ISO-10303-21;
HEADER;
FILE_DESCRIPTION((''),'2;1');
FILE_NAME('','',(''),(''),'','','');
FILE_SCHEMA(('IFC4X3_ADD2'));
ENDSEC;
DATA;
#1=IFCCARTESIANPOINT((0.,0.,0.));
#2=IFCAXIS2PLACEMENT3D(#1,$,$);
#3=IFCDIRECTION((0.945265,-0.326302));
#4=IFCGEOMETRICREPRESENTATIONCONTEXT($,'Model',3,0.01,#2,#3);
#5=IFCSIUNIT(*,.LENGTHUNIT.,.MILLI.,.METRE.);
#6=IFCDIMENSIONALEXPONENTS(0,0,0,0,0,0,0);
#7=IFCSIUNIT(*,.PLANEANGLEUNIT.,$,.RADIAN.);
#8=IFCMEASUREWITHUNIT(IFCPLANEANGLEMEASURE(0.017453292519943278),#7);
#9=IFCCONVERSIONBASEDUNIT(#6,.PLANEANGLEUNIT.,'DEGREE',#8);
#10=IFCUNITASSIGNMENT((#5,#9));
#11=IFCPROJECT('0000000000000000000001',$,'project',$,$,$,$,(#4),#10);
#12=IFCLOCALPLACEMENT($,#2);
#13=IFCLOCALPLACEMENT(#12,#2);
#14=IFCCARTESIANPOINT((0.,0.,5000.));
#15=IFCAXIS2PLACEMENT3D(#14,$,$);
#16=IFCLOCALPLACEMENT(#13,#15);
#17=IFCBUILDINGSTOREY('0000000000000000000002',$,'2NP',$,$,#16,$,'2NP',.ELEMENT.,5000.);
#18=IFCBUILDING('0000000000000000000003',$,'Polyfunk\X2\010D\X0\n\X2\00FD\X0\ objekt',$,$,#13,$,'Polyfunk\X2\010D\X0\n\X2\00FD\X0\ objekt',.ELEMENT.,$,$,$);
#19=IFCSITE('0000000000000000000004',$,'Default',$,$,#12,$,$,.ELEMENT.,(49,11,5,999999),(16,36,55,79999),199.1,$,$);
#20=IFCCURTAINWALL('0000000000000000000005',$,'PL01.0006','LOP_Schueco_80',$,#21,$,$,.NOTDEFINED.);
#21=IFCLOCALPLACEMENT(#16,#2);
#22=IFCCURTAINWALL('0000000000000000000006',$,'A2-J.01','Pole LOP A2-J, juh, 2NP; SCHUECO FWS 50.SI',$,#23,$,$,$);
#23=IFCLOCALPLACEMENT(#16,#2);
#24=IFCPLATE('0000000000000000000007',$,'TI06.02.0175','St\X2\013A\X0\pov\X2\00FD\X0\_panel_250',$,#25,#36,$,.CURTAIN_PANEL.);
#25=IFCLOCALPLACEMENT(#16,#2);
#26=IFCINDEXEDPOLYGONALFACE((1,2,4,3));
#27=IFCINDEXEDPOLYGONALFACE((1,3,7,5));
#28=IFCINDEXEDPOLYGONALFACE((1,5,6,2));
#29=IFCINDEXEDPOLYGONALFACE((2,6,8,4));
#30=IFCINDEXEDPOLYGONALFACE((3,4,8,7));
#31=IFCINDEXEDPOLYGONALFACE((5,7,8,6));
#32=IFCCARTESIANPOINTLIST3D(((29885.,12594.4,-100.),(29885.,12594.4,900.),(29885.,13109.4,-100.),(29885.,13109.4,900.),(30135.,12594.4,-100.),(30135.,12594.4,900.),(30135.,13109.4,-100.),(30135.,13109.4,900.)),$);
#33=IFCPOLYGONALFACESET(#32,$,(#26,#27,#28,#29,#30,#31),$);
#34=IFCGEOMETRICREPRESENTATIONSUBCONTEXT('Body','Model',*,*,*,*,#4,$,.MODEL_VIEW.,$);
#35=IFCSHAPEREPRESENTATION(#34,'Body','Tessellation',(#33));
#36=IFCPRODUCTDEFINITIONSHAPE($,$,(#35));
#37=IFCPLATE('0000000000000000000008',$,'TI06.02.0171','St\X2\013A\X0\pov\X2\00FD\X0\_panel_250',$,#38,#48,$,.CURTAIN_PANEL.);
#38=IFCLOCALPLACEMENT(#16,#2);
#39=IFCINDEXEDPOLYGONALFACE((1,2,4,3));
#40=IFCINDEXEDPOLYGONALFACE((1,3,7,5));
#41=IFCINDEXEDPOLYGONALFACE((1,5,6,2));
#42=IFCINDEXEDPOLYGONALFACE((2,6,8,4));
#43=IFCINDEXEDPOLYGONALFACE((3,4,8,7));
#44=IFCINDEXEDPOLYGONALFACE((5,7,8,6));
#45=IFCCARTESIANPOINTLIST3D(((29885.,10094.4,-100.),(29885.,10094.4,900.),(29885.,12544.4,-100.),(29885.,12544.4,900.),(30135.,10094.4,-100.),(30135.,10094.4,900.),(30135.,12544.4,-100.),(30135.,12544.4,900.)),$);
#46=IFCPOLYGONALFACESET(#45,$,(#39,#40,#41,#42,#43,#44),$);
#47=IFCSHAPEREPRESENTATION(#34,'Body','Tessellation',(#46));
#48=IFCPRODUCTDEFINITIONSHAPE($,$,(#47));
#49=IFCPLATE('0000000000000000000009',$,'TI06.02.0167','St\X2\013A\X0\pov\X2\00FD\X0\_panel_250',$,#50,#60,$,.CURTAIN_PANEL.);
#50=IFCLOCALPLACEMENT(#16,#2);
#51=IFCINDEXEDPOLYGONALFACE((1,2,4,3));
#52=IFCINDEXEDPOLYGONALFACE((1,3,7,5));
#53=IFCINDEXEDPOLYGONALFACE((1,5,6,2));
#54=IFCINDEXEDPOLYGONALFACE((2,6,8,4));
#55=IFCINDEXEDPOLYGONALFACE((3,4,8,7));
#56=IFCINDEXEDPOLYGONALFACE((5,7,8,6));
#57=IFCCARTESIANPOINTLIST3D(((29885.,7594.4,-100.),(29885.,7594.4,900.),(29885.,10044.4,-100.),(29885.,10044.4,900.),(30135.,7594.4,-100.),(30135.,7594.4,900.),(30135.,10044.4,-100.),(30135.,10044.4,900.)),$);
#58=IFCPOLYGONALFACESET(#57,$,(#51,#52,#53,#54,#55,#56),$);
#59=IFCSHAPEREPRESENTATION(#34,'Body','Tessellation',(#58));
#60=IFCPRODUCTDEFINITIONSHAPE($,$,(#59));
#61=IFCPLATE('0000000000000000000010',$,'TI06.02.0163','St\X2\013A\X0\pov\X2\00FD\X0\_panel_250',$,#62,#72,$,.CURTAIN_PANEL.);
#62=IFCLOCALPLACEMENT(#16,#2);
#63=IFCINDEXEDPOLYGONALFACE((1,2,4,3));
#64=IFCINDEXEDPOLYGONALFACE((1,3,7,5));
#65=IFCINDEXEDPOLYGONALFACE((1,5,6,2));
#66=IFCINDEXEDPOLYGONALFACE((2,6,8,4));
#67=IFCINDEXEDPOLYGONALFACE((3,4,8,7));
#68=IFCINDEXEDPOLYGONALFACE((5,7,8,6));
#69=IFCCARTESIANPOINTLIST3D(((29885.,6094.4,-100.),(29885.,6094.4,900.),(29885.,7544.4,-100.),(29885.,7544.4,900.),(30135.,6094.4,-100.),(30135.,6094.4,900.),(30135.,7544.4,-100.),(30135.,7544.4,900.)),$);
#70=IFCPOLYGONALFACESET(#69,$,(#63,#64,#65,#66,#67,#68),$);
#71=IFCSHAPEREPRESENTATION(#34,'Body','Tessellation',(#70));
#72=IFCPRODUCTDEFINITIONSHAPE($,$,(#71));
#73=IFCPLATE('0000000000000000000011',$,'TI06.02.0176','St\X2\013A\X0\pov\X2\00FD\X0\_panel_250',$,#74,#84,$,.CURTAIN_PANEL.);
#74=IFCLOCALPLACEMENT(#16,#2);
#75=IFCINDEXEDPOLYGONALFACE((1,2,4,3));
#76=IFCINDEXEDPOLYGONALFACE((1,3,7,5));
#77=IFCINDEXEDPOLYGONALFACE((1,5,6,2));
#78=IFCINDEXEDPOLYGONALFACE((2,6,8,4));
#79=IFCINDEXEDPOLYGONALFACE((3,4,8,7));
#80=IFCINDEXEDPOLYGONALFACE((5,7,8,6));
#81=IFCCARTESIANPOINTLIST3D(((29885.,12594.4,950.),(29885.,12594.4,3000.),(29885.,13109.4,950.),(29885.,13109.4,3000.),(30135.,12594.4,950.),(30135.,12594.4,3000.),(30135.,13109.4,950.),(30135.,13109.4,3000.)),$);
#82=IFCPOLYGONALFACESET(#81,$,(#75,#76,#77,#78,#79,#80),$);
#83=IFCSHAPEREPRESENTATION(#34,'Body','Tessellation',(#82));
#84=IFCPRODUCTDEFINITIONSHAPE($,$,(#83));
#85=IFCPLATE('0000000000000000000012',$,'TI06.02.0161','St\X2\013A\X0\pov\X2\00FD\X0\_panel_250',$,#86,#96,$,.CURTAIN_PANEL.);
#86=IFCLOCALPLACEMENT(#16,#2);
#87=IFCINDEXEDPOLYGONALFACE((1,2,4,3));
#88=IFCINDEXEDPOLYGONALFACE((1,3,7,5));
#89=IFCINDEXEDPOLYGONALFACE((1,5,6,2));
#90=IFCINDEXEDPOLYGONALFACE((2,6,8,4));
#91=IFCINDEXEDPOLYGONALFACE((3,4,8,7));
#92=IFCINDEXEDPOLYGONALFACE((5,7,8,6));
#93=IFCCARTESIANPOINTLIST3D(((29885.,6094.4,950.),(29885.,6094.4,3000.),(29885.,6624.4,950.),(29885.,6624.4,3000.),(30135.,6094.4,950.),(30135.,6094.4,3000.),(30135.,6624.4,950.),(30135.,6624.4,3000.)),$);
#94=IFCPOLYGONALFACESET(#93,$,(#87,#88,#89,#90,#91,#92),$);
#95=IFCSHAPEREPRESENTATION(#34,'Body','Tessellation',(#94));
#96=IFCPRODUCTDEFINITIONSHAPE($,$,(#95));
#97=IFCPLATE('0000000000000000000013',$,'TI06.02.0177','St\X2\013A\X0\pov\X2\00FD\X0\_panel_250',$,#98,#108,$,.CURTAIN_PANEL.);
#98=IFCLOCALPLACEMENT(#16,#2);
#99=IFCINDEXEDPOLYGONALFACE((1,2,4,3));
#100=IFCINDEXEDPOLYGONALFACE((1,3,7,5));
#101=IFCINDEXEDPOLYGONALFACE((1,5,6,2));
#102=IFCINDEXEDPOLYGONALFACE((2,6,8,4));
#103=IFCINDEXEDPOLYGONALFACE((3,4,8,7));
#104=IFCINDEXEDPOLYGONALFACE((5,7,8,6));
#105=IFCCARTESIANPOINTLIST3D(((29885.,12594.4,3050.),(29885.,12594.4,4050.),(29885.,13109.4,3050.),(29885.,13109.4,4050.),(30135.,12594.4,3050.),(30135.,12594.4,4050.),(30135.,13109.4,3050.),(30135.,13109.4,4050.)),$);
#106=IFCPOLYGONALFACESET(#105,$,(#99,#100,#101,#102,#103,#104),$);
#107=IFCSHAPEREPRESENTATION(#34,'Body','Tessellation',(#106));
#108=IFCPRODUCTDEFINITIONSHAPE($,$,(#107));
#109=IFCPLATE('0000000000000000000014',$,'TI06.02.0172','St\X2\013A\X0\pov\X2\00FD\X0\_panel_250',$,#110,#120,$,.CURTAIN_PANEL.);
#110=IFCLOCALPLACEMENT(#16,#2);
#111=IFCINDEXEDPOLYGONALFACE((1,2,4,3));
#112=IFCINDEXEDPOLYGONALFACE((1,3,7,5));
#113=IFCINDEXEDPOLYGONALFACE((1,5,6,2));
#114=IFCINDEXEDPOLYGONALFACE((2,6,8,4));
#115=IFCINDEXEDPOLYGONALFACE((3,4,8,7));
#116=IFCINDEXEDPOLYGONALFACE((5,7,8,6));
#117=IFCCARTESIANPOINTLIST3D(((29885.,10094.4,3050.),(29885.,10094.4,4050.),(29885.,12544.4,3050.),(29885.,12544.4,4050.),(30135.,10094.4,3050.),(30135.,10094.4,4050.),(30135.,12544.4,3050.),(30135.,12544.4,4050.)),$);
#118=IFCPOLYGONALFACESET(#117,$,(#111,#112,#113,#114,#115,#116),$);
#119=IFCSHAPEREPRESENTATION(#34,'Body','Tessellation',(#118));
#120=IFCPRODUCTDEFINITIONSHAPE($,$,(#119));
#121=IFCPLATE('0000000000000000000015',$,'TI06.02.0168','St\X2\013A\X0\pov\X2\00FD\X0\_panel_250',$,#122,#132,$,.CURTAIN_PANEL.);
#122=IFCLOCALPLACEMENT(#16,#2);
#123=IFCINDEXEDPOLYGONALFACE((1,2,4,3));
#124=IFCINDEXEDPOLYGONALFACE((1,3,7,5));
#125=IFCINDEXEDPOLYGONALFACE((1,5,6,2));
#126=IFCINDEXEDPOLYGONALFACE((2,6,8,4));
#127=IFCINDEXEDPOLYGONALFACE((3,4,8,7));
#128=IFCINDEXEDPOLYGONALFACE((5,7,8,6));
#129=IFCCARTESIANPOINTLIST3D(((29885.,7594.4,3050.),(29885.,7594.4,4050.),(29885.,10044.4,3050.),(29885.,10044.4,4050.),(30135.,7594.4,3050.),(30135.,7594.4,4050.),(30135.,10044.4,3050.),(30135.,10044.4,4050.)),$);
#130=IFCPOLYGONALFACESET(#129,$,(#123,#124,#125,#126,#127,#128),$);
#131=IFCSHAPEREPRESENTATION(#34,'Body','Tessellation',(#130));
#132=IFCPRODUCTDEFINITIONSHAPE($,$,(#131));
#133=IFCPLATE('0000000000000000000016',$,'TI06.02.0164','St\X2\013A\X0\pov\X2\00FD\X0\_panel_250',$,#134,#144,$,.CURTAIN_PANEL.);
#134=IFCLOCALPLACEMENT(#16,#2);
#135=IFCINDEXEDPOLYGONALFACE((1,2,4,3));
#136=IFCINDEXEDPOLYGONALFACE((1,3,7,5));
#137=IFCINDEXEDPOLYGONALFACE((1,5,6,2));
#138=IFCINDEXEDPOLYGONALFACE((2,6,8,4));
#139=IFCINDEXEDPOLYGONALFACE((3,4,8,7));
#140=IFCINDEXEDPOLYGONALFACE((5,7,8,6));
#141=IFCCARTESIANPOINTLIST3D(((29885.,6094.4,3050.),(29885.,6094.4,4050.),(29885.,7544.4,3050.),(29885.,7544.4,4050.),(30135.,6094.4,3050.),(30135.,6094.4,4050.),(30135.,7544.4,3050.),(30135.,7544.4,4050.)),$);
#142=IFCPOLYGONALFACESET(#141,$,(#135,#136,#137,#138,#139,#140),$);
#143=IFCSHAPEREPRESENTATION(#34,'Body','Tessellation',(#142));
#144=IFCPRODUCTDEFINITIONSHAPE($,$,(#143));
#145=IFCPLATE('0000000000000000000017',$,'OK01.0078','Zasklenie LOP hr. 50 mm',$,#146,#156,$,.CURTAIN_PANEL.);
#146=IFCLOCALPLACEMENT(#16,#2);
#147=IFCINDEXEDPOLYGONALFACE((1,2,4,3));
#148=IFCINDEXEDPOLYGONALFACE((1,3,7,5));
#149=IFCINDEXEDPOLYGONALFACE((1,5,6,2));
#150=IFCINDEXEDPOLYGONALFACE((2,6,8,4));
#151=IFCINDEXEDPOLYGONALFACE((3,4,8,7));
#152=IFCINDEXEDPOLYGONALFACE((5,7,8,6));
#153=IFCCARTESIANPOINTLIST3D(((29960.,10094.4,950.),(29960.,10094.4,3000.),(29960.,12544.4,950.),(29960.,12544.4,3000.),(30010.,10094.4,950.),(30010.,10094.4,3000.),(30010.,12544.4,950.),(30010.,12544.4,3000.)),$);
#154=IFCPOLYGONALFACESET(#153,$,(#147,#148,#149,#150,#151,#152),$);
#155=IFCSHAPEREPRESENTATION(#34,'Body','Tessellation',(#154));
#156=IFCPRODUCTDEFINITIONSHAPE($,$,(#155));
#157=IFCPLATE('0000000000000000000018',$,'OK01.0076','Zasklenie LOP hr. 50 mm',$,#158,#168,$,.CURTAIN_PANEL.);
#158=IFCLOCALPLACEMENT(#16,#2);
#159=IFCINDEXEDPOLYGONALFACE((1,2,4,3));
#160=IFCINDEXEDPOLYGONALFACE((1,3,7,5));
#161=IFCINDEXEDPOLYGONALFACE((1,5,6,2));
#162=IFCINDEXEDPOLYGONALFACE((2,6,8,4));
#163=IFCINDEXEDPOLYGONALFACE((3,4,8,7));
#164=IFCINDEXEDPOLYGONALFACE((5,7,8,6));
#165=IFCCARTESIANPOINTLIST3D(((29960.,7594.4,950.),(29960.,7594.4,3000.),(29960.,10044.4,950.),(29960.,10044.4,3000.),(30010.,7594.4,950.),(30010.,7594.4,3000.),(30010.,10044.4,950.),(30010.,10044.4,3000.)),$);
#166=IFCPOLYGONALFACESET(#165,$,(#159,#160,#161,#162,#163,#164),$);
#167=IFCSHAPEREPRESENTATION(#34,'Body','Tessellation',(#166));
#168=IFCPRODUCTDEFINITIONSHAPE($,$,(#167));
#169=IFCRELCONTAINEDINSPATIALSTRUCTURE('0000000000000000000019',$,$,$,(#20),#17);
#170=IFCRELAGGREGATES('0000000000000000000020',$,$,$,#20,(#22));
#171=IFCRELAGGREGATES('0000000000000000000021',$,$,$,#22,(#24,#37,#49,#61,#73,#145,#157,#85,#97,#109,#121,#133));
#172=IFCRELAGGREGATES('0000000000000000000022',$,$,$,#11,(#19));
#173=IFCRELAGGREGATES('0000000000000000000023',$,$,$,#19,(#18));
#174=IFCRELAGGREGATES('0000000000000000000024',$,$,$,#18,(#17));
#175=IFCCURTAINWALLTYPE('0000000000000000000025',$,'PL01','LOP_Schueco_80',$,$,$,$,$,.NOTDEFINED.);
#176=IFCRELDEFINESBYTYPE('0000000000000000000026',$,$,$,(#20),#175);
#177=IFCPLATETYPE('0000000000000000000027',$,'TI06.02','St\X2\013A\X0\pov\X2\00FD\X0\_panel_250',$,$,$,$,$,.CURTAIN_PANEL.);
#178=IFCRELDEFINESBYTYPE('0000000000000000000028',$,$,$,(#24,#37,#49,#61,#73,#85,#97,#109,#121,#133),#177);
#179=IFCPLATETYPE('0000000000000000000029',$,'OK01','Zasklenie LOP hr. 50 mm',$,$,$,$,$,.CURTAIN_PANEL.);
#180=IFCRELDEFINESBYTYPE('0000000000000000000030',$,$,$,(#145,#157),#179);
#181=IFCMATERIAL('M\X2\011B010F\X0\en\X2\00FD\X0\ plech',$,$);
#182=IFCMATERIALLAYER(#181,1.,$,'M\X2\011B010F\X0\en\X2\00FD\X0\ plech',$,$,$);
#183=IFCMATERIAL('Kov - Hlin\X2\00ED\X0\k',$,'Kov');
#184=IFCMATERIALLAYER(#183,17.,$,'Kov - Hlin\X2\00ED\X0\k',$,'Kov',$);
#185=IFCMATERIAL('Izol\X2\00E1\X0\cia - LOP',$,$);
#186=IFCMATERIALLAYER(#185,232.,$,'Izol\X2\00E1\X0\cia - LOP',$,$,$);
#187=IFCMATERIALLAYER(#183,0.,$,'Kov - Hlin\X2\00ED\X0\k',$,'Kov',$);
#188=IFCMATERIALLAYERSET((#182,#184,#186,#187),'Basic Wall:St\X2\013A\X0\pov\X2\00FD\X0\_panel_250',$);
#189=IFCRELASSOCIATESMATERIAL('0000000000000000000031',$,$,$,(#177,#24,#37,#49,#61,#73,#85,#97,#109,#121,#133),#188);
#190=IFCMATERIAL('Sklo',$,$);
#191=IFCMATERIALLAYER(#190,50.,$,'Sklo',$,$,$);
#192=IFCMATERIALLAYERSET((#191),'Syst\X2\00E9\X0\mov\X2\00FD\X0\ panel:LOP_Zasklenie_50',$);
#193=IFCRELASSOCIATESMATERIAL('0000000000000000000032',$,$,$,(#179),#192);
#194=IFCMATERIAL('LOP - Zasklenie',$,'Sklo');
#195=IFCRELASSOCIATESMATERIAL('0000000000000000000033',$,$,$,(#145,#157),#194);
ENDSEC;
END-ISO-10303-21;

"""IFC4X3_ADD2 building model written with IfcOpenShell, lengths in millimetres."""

from ifc_helpers import new_model, entity, si_unit, converted_unit, direction, frame, frame_2d, origin, origin_2d_with_axis, place, context, subcontext, project, spatial, rectangle, extrude, source, transform, mapped, material, layer, layer_set, layer_usage, type_object, element, aggregate, save


model = new_model("IFC4X3_ADD2")

# Units and contexts
model_context = context("Model", 3, precision=0.01, world=origin(), true_north=direction((0.945265, -0.326302)))
body_context = subcontext(model_context, "Body", "Model", "MODEL_VIEW")
ifc_project = project(units=[si_unit("LENGTHUNIT", "METRE", prefix="MILLI"), converted_unit("PLANEANGLEUNIT", "DEGREE", entity("IfcPlaneAngleMeasure", 0.017453292519943278), si_unit("PLANEANGLEUNIT", "RADIAN"), dimensions=[0, 0, 0, 0, 0, 0, 0])], contexts=[model_context])

# Site, building, storey
site_placement = place(None, origin())
site = spatial("IfcSite", under=ifc_project, at=site_placement, Name="Default", CompositionType="ELEMENT", RefLatitude=(49, 11, 5, 999999), RefLongitude=(16, 36, 55, 79999), RefElevation=199.1)
building_placement = place(site_placement, origin())
building = spatial("IfcBuilding", under=site, at=building_placement, Name="Polyfunkčný objekt", LongName="Polyfunkčný objekt", CompositionType="ELEMENT")
storey_placement = place(building_placement, frame((0.0, 0.0, 5000.0)))
storey = spatial("IfcBuildingStorey", under=building, at=storey_placement, Name="2NP", LongName="2NP", CompositionType="ELEMENT", Elevation=5000.0)

# Shared definitions
curtain_wall_type = type_object("IfcCurtainWallType", Name="PL01", Description="LOP_Schueco_80", PredefinedType="NOTDEFINED")

# Curtain walls, plates
curtain_wall_1_placement = place(storey_placement, frame((0.0, 0.0, -5000.0)))
curtain_wall_1 = element("IfcCurtainWall", 1, at=curtain_wall_1_placement, inside=storey, type_object=curtain_wall_type, Name="PL01.0006", Description="LOP_Schueco_80", PredefinedType="NOTDEFINED")
curtain_wall_2 = element("IfcCurtainWall", 2, Name="A2-J.01", Description="Pole LOP A2-J, juh, 2NP; SCHUECO FWS 50.SI")
aggregate(curtain_wall_1, [curtain_wall_2])
ifc_material_1 = material(Name="Měďený plech")
ifc_layer_1 = layer(ifc_material_1, 1.0, Name="Měďený plech")
ifc_material_2 = material(Name="Kov - Hliník", Category="Kov")
ifc_layer_2 = layer(ifc_material_2, 17.0, Name="Kov - Hliník", Category="Kov")
ifc_material_3 = material(Name="Izolácia - LOP")
ifc_layer_3 = layer(ifc_material_3, 232.0, Name="Izolácia - LOP")
ifc_layer_4 = layer(ifc_material_2, 0.0, Name="Kov - Hliník", Category="Kov")
ifc_layer_set_1 = layer_set([ifc_layer_1, ifc_layer_2, ifc_layer_3, ifc_layer_4], Name="Basic Wall:Stĺpový_panel_250")
ifc_layer_usage_1 = layer_usage(ifc_layer_set_1, "AXIS2", "POSITIVE", -125.0)
plate_type_1 = type_object("IfcPlateType", Name="TI06.02", Description="Stĺpový_panel_250", PredefinedType="CURTAIN_PANEL", material=ifc_layer_set_1)
plate_1_placement = place(storey_placement, frame((30010.0, 13109.4, -100.0), z_axis=(0.0, 0.0, 1.0), x_axis=(0.0, -1.0, 0.0)))
plate_1 = element("IfcPlate", 3, at=plate_1_placement, type_object=plate_type_1, material=ifc_layer_usage_1, Name="TI06.02.0175", Description="Stĺpový_panel_250", PredefinedType="CURTAIN_PANEL", context=body_context, shape_type="SweptSolid", body=[
    extrude(rectangle(XDim=250.0, YDim=515.0, at=frame_2d((0.0, 0.0), x_axis=(1.0, 0.0))), frame((257.5, 0.0, 0.0), z_axis=(0.0, 0.0, 1.0), x_axis=(0.0, 1.0, 0.0)), (0.0, 0.0, 1.0), 1000.0),
])
ifc_layer_usage_2 = layer_usage(ifc_layer_set_1, "AXIS2", "POSITIVE", -125.0)
plate_2_placement = place(storey_placement, frame((30010.0, 12544.4, -100.0), z_axis=(0.0, 0.0, 1.0), x_axis=(0.0, -1.0, 0.0)))
plate_2 = element("IfcPlate", 4, at=plate_2_placement, type_object=plate_type_1, material=ifc_layer_usage_2, Name="TI06.02.0171", Description="Stĺpový_panel_250", PredefinedType="CURTAIN_PANEL", context=body_context, shape_type="SweptSolid", body=[
    extrude(rectangle(XDim=250.0, YDim=2450.0, at=frame_2d((0.0, 0.0), x_axis=(1.0, 0.0))), frame((1225.0, 0.0, 0.0), z_axis=(0.0, 0.0, 1.0), x_axis=(0.0, 1.0, 0.0)), (0.0, 0.0, 1.0), 1000.0),
])
ifc_layer_usage_3 = layer_usage(ifc_layer_set_1, "AXIS2", "POSITIVE", -125.0)
plate_3_placement = place(storey_placement, frame((30010.0, 10044.4, -100.0), z_axis=(0.0, 0.0, 1.0), x_axis=(0.0, -1.0, 0.0)))
plate_3 = element("IfcPlate", 5, at=plate_3_placement, type_object=plate_type_1, material=ifc_layer_usage_3, Name="TI06.02.0167", Description="Stĺpový_panel_250", PredefinedType="CURTAIN_PANEL", context=body_context, shape_type="SweptSolid", body=[
    extrude(rectangle(XDim=250.0, YDim=2450.0, at=origin_2d_with_axis()), frame((1225.0, 0.0, 0.0), z_axis=(0.0, 0.0, 1.0), x_axis=(0.0, 1.0, 0.0)), (0.0, 0.0, 1.0), 1000.0),
])
ifc_layer_usage_4 = layer_usage(ifc_layer_set_1, "AXIS2", "POSITIVE", -125.0)
plate_4_placement = place(storey_placement, frame((30010.0, 7544.4, -100.0), z_axis=(0.0, 0.0, 1.0), x_axis=(0.0, -1.0, 0.0)))
plate_4 = element("IfcPlate", 6, at=plate_4_placement, type_object=plate_type_1, material=ifc_layer_usage_4, Name="TI06.02.0163", Description="Stĺpový_panel_250", PredefinedType="CURTAIN_PANEL", context=body_context, shape_type="SweptSolid", body=[
    extrude(rectangle(XDim=250.0, YDim=1450.0, at=frame_2d((0.0, 0.0), x_axis=(1.0, 0.0))), frame((725.0, 0.0, 0.0), z_axis=(0.0, 0.0, 1.0), x_axis=(0.0, 1.0, 0.0)), (0.0, 0.0, 1.0), 1000.0),
])
ifc_layer_usage_5 = layer_usage(ifc_layer_set_1, "AXIS2", "POSITIVE", -125.0)
plate_5_placement = place(storey_placement, frame((30010.0, 13109.4, 950.0), z_axis=(0.0, 0.0, 1.0), x_axis=(0.0, -1.0, 0.0)))
plate_5 = element("IfcPlate", 7, at=plate_5_placement, type_object=plate_type_1, material=ifc_layer_usage_5, Name="TI06.02.0176", Description="Stĺpový_panel_250", PredefinedType="CURTAIN_PANEL", context=body_context, shape_type="SweptSolid", body=[
    extrude(rectangle(XDim=250.0, YDim=515.0, at=frame_2d((0.0, 0.0), x_axis=(1.0, 0.0))), frame((257.5, 0.0, 0.0), z_axis=(0.0, 0.0, 1.0), x_axis=(0.0, 1.0, 0.0)), (0.0, 0.0, 1.0), 2050.0),
])
ifc_layer_usage_6 = layer_usage(ifc_layer_set_1, "AXIS2", "POSITIVE", -125.0)
plate_6_placement = place(storey_placement, frame((30010.0, 6624.4, 950.0), z_axis=(0.0, 0.0, 1.0), x_axis=(0.0, -1.0, 0.0)))
plate_6 = element("IfcPlate", 8, at=plate_6_placement, type_object=plate_type_1, material=ifc_layer_usage_6, Name="TI06.02.0161", Description="Stĺpový_panel_250", PredefinedType="CURTAIN_PANEL", context=body_context, shape_type="SweptSolid", body=[
    extrude(rectangle(XDim=250.0, YDim=530.0, at=frame_2d((0.0, 0.0), x_axis=(1.0, 0.0))), frame((265.0, 0.0, 0.0), z_axis=(0.0, 0.0, 1.0), x_axis=(0.0, 1.0, 0.0)), (0.0, 0.0, 1.0), 2050.0),
])
ifc_layer_usage_7 = layer_usage(ifc_layer_set_1, "AXIS2", "POSITIVE", -125.0)
plate_7_placement = place(storey_placement, frame((30010.0, 13109.4, 3050.0), z_axis=(0.0, 0.0, 1.0), x_axis=(0.0, -1.0, 0.0)))
plate_7 = element("IfcPlate", 9, at=plate_7_placement, type_object=plate_type_1, material=ifc_layer_usage_7, Name="TI06.02.0177", Description="Stĺpový_panel_250", PredefinedType="CURTAIN_PANEL", context=body_context, shape_type="SweptSolid", body=[
    extrude(rectangle(XDim=250.0, YDim=515.0, at=frame_2d((0.0, 0.0), x_axis=(1.0, 0.0))), frame((257.5, 0.0, 0.0), z_axis=(0.0, 0.0, 1.0), x_axis=(0.0, 1.0, 0.0)), (0.0, 0.0, 1.0), 1000.0),
])
ifc_layer_usage_8 = layer_usage(ifc_layer_set_1, "AXIS2", "POSITIVE", -125.0)
plate_8_placement = place(storey_placement, frame((30010.0, 12544.4, 3050.0), z_axis=(0.0, 0.0, 1.0), x_axis=(0.0, -1.0, 0.0)))
plate_8 = element("IfcPlate", 10, at=plate_8_placement, type_object=plate_type_1, material=ifc_layer_usage_8, Name="TI06.02.0172", Description="Stĺpový_panel_250", PredefinedType="CURTAIN_PANEL", context=body_context, shape_type="SweptSolid", body=[
    extrude(rectangle(XDim=250.0, YDim=2450.0, at=frame_2d((0.0, 0.0), x_axis=(1.0, 0.0))), frame((1225.0, 0.0, 0.0), z_axis=(0.0, 0.0, 1.0), x_axis=(0.0, 1.0, 0.0)), (0.0, 0.0, 1.0), 1000.0),
])
ifc_layer_usage_9 = layer_usage(ifc_layer_set_1, "AXIS2", "POSITIVE", -125.0)
plate_9_placement = place(storey_placement, frame((30010.0, 10044.4, 3050.0), z_axis=(0.0, 0.0, 1.0), x_axis=(0.0, -1.0, 0.0)))
plate_9 = element("IfcPlate", 11, at=plate_9_placement, type_object=plate_type_1, material=ifc_layer_usage_9, Name="TI06.02.0168", Description="Stĺpový_panel_250", PredefinedType="CURTAIN_PANEL", context=body_context, shape_type="SweptSolid", body=[
    extrude(rectangle(XDim=250.0, YDim=2450.0, at=origin_2d_with_axis()), frame((1225.0, 0.0, 0.0), z_axis=(0.0, 0.0, 1.0), x_axis=(0.0, 1.0, 0.0)), (0.0, 0.0, 1.0), 1000.0),
])
ifc_layer_usage_10 = layer_usage(ifc_layer_set_1, "AXIS2", "POSITIVE", -125.0)
plate_10_placement = place(storey_placement, frame((30010.0, 7544.4, 3050.0), z_axis=(0.0, 0.0, 1.0), x_axis=(0.0, -1.0, 0.0)))
plate_10 = element("IfcPlate", 12, at=plate_10_placement, type_object=plate_type_1, material=ifc_layer_usage_10, Name="TI06.02.0164", Description="Stĺpový_panel_250", PredefinedType="CURTAIN_PANEL", context=body_context, shape_type="SweptSolid", body=[
    extrude(rectangle(XDim=250.0, YDim=1450.0, at=frame_2d((0.0, 0.0), x_axis=(1.0, 0.0))), frame((725.0, 0.0, 0.0), z_axis=(0.0, 0.0, 1.0), x_axis=(0.0, 1.0, 0.0)), (0.0, 0.0, 1.0), 1000.0),
])
ifc_material_4 = material(Name="LOP - Zasklenie", Category="Sklo")
ifc_material_5 = material(Name="Sklo")
ifc_layer_5 = layer(ifc_material_5, 50.0, Name="Sklo")
ifc_layer_set_2 = layer_set([ifc_layer_5], Name="Systémový panel:LOP_Zasklenie_50")
plate_type_2 = type_object("IfcPlateType", Name="OK01", Description="Zasklenie LOP hr. 50 mm", PredefinedType="CURTAIN_PANEL", material=ifc_layer_set_2)
shared_shape_1 = source(origin(), body_context, "Body", "SweptSolid", [
    extrude(rectangle(XDim=50.0, YDim=2450.0, at=origin_2d_with_axis()), frame((0.0, -25.0, 0.0), z_axis=(0.0, 0.0, 1.0), x_axis=(0.0, 1.0, 0.0)), (0.0, 0.0, 1.0), 2050.0),
])
plate_11_placement = place(curtain_wall_1_placement, frame((30010.0, 11319.4, 5950.0), z_axis=(0.0, 0.0, 1.0), x_axis=(0.0, -1.0, 0.0)))
plate_11 = element("IfcPlate", 13, at=plate_11_placement, type_object=plate_type_2, material=ifc_material_4, Name="OK01.0078", Description="Zasklenie LOP hr. 50 mm", PredefinedType="CURTAIN_PANEL", context=body_context, shape_type="MappedRepresentation", body=[
    mapped(shared_shape_1, transform((0.0, 0.0, 0.0), scale=1.0)),
])
plate_12_placement = place(curtain_wall_1_placement, frame((30010.0, 8819.4, 5950.0), z_axis=(0.0, 0.0, 1.0), x_axis=(0.0, -1.0, 0.0)))
plate_12 = element("IfcPlate", 14, at=plate_12_placement, type_object=plate_type_2, material=ifc_material_4, Name="OK01.0076", Description="Zasklenie LOP hr. 50 mm", PredefinedType="CURTAIN_PANEL", context=body_context, shape_type="MappedRepresentation", body=[
    mapped(shared_shape_1, transform((0.0, 0.0, 0.0), scale=1.0)),
])
aggregate(curtain_wall_2, [plate_1, plate_2, plate_3, plate_4, plate_5, plate_11, plate_12, plate_6, plate_7, plate_8, plate_9, plate_10])

save(model, "model.ifc")
